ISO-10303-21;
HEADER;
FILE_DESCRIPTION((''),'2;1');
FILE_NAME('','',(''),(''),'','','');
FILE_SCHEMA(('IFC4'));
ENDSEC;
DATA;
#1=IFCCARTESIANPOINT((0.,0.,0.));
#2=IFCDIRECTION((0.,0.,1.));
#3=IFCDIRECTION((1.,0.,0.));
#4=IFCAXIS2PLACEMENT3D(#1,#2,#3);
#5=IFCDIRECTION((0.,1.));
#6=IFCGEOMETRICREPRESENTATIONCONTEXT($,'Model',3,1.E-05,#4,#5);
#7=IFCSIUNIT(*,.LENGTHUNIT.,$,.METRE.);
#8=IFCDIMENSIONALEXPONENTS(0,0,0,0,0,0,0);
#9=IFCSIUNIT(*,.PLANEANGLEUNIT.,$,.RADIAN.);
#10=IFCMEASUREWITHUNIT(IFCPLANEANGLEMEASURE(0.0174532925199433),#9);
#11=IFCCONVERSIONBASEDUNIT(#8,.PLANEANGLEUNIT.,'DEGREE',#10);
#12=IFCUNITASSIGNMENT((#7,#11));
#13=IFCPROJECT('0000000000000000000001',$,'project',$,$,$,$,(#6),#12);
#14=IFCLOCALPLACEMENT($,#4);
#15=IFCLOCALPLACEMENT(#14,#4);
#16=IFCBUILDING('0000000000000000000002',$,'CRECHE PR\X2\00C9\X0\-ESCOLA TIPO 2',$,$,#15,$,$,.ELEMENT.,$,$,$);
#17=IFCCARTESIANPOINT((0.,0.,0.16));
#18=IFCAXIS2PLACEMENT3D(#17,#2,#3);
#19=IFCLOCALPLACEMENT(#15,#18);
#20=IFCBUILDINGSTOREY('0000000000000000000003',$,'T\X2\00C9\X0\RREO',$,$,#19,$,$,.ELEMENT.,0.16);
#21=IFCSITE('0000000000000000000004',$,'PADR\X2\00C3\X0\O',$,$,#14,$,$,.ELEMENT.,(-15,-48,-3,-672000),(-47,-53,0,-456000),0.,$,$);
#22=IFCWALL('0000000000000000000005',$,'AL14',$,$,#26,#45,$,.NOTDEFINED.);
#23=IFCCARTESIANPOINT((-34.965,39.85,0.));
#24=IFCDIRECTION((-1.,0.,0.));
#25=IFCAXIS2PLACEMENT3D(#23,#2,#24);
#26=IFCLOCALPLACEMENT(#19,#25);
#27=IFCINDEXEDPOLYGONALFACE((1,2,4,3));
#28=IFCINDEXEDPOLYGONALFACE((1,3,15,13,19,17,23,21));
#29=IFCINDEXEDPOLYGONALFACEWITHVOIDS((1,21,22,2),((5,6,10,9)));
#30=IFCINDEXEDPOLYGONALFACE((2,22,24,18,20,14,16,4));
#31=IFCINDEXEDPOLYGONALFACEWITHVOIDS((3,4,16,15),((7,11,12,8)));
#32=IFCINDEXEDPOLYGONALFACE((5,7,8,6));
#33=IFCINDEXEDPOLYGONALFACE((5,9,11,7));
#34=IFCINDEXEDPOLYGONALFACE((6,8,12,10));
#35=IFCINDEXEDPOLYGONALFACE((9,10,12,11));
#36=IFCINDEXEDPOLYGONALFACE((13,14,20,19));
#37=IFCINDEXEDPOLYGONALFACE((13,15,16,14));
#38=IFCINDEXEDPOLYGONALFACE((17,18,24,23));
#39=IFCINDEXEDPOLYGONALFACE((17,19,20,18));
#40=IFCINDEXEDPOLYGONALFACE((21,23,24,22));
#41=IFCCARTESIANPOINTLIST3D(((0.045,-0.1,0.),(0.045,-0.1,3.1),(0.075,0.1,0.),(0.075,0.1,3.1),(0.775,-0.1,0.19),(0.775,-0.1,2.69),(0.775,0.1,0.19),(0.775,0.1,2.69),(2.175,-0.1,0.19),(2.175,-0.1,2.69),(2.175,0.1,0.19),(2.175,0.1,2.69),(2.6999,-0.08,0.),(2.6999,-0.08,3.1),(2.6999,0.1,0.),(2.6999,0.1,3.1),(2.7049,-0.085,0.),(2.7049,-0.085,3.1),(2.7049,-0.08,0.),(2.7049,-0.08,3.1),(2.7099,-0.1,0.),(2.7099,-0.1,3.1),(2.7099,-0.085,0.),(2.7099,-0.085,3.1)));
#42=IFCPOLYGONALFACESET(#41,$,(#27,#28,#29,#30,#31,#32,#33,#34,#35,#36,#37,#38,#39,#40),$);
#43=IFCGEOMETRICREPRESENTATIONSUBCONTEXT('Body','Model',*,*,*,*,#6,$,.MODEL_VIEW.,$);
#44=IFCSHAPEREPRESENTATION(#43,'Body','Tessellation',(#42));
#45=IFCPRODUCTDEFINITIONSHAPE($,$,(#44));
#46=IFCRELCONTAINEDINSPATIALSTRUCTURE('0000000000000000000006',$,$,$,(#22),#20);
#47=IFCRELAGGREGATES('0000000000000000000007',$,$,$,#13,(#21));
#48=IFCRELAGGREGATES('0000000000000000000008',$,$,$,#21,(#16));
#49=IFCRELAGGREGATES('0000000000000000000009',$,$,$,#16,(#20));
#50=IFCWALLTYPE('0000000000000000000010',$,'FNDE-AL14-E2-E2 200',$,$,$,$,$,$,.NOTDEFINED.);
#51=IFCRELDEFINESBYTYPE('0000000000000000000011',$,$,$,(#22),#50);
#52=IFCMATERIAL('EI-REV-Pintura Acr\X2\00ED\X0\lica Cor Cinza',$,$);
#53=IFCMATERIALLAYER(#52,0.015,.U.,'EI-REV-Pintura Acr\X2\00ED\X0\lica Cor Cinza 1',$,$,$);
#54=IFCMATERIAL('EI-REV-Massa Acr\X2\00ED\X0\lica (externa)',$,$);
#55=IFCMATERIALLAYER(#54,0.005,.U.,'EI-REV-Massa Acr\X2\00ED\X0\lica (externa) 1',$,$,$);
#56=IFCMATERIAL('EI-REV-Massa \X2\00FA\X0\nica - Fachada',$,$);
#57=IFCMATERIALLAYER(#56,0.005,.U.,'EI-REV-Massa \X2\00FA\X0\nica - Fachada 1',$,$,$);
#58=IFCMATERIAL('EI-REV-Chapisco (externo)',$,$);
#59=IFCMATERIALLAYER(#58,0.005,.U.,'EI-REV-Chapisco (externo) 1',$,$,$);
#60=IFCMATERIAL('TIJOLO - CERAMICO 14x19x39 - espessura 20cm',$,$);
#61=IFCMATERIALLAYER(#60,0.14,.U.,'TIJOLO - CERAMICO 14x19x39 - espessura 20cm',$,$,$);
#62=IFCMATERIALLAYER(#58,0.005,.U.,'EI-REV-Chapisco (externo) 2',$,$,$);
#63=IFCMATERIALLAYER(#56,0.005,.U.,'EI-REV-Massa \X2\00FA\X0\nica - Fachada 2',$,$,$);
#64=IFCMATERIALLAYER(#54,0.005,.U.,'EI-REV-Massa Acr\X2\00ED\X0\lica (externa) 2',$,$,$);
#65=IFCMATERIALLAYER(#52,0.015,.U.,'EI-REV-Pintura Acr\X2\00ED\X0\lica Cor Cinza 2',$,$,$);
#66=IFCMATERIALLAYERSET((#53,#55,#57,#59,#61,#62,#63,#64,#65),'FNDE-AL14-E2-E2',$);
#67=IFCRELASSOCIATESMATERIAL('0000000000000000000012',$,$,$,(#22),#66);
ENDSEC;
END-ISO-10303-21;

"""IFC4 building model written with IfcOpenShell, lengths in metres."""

from ifc_helpers import new_model, entity, si_unit, converted_unit, direction, frame, origin_with_axes, origin_2d_with_axis, place, context, subcontext, project, spatial, line, indexed_curve, rectangle, outline, extrude, material, layer, layer_set, layer_usage, type_object, element, save


model = new_model("IFC4")

# Units and contexts
model_context = context("Model", 3, precision=1e-05, world=origin_with_axes(), true_north=direction((0.0, 1.0)))
body_context = subcontext(model_context, "Body", "Model", "MODEL_VIEW")
ifc_project = project(units=[si_unit("LENGTHUNIT", "METRE"), converted_unit("PLANEANGLEUNIT", "DEGREE", entity("IfcPlaneAngleMeasure", 0.0174532925199433), si_unit("PLANEANGLEUNIT", "RADIAN"), dimensions=[0, 0, 0, 0, 0, 0, 0])], contexts=[model_context])

# Site, building, storey
site_placement = place(None, origin_with_axes())
site = spatial("IfcSite", under=ifc_project, at=site_placement, Name="PADRÃO", CompositionType="ELEMENT", RefLatitude=(-15, -48, -3, -672000), RefLongitude=(-47, -53, 0, -456000), RefElevation=0.0)
building_placement = place(site_placement, origin_with_axes())
building = spatial("IfcBuilding", under=site, at=building_placement, Name="CRECHE PRÉ-ESCOLA TIPO 2", CompositionType="ELEMENT")
storey_placement = place(building_placement, frame((0.0, 0.0, 0.16), z_axis=(0.0, 0.0, 1.0), x_axis=(1.0, 0.0, 0.0)))
storey = spatial("IfcBuildingStorey", under=building, at=storey_placement, Name="TÉRREO", CompositionType="ELEMENT", Elevation=0.16)

# Shared definitions
ifc_material_1 = material(Name="TIJOLO - CERAMICO 14x19x39 - espessura 20cm")
ifc_material_2 = material(Name="EI-REV-Chapisco (externo)")
ifc_material_3 = material(Name="EI-REV-Pintura Acrílica Cor Cinza")
ifc_material_4 = material(Name="EI-REV-Massa única - Fachada")
ifc_material_5 = material(Name="EI-REV-Massa Acrílica (externa)")

# Wall, openings
ifc_layer_1 = layer(ifc_material_3, 0.015, ventilated="UNKNOWN", Name="EI-REV-Pintura Acrílica Cor Cinza 1")
ifc_layer_2 = layer(ifc_material_5, 0.005, ventilated="UNKNOWN", Name="EI-REV-Massa Acrílica (externa) 1")
ifc_layer_3 = layer(ifc_material_4, 0.005, ventilated="UNKNOWN", Name="EI-REV-Massa única - Fachada 1")
ifc_layer_4 = layer(ifc_material_2, 0.005, ventilated="UNKNOWN", Name="EI-REV-Chapisco (externo) 1")
ifc_layer_5 = layer(ifc_material_1, 0.14, ventilated="UNKNOWN", Name="TIJOLO - CERAMICO 14x19x39 - espessura 20cm")
ifc_layer_6 = layer(ifc_material_2, 0.005, ventilated="UNKNOWN", Name="EI-REV-Chapisco (externo) 2")
ifc_layer_7 = layer(ifc_material_4, 0.005, ventilated="UNKNOWN", Name="EI-REV-Massa única - Fachada 2")
ifc_layer_8 = layer(ifc_material_5, 0.005, ventilated="UNKNOWN", Name="EI-REV-Massa Acrílica (externa) 2")
ifc_layer_9 = layer(ifc_material_3, 0.015, ventilated="UNKNOWN", Name="EI-REV-Pintura Acrílica Cor Cinza 2")
ifc_layer_set_1 = layer_set([ifc_layer_1, ifc_layer_2, ifc_layer_3, ifc_layer_4, ifc_layer_5, ifc_layer_6, ifc_layer_7, ifc_layer_8, ifc_layer_9], Name="FNDE-AL14-E2-E2")
ifc_layer_usage_1 = layer_usage(ifc_layer_set_1, "AXIS2", "POSITIVE", -0.1)
wall_type_1 = type_object("IfcWallType", Name="FNDE-AL14-E2-E2 200", PredefinedType="NOTDEFINED")
wall_1_placement = place(storey_placement, frame((-34.965, 39.85, 0.0), z_axis=(0.0, 0.0, 1.0), x_axis=(-1.0, 0.0, 0.0)))
wall_1 = element("IfcWall", 1, at=wall_1_placement, inside=storey, type_object=wall_type_1, material=ifc_layer_usage_1, Name="AL14", PredefinedType="NOTDEFINED", context=body_context, shape_type="SweptSolid", body=[
    extrude(outline(indexed_curve([(0.045, -0.1), (2.7249, -0.1), (2.7249, 0.1), (0.075, 0.1)], segments=[line(1, 2, 3, 4, 1)])), origin_with_axes(), (0.0, 0.0, 1.0), 3.1),
])
opening_1_placement = place(wall_1_placement, frame((2.7249, 0.0, 0.0), z_axis=(0.0, 0.0, 1.0), x_axis=(1.0, 0.0, 0.0)))
element("IfcOpeningElement", 2, at=opening_1_placement, cuts=wall_1, context=body_context, shape_type="SweptSolid", body=[
    extrude(rectangle(XDim=0.2, YDim=0.015, at=origin_2d_with_axis()), frame((-0.0075, 0.0, 0.0), z_axis=(0.0, 0.0, 1.0), x_axis=(0.0, -1.0, 0.0)), (0.0, 0.0, 1.0), 3.1),
    extrude(rectangle(XDim=0.185, YDim=0.005, at=origin_2d_with_axis()), frame((-0.0175, 0.0075, 0.0), z_axis=(0.0, 0.0, 1.0), x_axis=(0.0, -1.0, 0.0)), (0.0, 0.0, 1.0), 3.1),
    extrude(rectangle(XDim=0.18, YDim=0.005, at=origin_2d_with_axis()), frame((-0.0225, 0.01, 0.0), z_axis=(0.0, 0.0, 1.0), x_axis=(0.0, -1.0, 0.0)), (0.0, 0.0, 1.0), 3.1),
])
opening_2_placement = place(wall_1_placement, frame((1.475, 0.0, 0.19), z_axis=(0.0, 0.0, 1.0), x_axis=(1.0, 0.0, 0.0)))
element("IfcOpeningElement", 3, at=opening_2_placement, cuts=wall_1, context=body_context, shape_type="SweptSolid", body=[
    extrude(rectangle(XDim=1.4, YDim=2.5, at=origin_2d_with_axis()), frame((0.0, 0.07, 1.25), z_axis=(0.0, -1.0, 0.0), x_axis=(-1.0, 0.0, 0.0)), (0.0, 0.0, 1.0), 0.37),
    extrude(rectangle(XDim=1.4, YDim=2.5, at=origin_2d_with_axis()), frame((0.0, 0.07, 1.25), z_axis=(0.0, 1.0, 0.0), x_axis=(-1.0, 0.0, 0.0)), (0.0, 0.0, 1.0), 0.23),
])

save(model, "model.ifc")
